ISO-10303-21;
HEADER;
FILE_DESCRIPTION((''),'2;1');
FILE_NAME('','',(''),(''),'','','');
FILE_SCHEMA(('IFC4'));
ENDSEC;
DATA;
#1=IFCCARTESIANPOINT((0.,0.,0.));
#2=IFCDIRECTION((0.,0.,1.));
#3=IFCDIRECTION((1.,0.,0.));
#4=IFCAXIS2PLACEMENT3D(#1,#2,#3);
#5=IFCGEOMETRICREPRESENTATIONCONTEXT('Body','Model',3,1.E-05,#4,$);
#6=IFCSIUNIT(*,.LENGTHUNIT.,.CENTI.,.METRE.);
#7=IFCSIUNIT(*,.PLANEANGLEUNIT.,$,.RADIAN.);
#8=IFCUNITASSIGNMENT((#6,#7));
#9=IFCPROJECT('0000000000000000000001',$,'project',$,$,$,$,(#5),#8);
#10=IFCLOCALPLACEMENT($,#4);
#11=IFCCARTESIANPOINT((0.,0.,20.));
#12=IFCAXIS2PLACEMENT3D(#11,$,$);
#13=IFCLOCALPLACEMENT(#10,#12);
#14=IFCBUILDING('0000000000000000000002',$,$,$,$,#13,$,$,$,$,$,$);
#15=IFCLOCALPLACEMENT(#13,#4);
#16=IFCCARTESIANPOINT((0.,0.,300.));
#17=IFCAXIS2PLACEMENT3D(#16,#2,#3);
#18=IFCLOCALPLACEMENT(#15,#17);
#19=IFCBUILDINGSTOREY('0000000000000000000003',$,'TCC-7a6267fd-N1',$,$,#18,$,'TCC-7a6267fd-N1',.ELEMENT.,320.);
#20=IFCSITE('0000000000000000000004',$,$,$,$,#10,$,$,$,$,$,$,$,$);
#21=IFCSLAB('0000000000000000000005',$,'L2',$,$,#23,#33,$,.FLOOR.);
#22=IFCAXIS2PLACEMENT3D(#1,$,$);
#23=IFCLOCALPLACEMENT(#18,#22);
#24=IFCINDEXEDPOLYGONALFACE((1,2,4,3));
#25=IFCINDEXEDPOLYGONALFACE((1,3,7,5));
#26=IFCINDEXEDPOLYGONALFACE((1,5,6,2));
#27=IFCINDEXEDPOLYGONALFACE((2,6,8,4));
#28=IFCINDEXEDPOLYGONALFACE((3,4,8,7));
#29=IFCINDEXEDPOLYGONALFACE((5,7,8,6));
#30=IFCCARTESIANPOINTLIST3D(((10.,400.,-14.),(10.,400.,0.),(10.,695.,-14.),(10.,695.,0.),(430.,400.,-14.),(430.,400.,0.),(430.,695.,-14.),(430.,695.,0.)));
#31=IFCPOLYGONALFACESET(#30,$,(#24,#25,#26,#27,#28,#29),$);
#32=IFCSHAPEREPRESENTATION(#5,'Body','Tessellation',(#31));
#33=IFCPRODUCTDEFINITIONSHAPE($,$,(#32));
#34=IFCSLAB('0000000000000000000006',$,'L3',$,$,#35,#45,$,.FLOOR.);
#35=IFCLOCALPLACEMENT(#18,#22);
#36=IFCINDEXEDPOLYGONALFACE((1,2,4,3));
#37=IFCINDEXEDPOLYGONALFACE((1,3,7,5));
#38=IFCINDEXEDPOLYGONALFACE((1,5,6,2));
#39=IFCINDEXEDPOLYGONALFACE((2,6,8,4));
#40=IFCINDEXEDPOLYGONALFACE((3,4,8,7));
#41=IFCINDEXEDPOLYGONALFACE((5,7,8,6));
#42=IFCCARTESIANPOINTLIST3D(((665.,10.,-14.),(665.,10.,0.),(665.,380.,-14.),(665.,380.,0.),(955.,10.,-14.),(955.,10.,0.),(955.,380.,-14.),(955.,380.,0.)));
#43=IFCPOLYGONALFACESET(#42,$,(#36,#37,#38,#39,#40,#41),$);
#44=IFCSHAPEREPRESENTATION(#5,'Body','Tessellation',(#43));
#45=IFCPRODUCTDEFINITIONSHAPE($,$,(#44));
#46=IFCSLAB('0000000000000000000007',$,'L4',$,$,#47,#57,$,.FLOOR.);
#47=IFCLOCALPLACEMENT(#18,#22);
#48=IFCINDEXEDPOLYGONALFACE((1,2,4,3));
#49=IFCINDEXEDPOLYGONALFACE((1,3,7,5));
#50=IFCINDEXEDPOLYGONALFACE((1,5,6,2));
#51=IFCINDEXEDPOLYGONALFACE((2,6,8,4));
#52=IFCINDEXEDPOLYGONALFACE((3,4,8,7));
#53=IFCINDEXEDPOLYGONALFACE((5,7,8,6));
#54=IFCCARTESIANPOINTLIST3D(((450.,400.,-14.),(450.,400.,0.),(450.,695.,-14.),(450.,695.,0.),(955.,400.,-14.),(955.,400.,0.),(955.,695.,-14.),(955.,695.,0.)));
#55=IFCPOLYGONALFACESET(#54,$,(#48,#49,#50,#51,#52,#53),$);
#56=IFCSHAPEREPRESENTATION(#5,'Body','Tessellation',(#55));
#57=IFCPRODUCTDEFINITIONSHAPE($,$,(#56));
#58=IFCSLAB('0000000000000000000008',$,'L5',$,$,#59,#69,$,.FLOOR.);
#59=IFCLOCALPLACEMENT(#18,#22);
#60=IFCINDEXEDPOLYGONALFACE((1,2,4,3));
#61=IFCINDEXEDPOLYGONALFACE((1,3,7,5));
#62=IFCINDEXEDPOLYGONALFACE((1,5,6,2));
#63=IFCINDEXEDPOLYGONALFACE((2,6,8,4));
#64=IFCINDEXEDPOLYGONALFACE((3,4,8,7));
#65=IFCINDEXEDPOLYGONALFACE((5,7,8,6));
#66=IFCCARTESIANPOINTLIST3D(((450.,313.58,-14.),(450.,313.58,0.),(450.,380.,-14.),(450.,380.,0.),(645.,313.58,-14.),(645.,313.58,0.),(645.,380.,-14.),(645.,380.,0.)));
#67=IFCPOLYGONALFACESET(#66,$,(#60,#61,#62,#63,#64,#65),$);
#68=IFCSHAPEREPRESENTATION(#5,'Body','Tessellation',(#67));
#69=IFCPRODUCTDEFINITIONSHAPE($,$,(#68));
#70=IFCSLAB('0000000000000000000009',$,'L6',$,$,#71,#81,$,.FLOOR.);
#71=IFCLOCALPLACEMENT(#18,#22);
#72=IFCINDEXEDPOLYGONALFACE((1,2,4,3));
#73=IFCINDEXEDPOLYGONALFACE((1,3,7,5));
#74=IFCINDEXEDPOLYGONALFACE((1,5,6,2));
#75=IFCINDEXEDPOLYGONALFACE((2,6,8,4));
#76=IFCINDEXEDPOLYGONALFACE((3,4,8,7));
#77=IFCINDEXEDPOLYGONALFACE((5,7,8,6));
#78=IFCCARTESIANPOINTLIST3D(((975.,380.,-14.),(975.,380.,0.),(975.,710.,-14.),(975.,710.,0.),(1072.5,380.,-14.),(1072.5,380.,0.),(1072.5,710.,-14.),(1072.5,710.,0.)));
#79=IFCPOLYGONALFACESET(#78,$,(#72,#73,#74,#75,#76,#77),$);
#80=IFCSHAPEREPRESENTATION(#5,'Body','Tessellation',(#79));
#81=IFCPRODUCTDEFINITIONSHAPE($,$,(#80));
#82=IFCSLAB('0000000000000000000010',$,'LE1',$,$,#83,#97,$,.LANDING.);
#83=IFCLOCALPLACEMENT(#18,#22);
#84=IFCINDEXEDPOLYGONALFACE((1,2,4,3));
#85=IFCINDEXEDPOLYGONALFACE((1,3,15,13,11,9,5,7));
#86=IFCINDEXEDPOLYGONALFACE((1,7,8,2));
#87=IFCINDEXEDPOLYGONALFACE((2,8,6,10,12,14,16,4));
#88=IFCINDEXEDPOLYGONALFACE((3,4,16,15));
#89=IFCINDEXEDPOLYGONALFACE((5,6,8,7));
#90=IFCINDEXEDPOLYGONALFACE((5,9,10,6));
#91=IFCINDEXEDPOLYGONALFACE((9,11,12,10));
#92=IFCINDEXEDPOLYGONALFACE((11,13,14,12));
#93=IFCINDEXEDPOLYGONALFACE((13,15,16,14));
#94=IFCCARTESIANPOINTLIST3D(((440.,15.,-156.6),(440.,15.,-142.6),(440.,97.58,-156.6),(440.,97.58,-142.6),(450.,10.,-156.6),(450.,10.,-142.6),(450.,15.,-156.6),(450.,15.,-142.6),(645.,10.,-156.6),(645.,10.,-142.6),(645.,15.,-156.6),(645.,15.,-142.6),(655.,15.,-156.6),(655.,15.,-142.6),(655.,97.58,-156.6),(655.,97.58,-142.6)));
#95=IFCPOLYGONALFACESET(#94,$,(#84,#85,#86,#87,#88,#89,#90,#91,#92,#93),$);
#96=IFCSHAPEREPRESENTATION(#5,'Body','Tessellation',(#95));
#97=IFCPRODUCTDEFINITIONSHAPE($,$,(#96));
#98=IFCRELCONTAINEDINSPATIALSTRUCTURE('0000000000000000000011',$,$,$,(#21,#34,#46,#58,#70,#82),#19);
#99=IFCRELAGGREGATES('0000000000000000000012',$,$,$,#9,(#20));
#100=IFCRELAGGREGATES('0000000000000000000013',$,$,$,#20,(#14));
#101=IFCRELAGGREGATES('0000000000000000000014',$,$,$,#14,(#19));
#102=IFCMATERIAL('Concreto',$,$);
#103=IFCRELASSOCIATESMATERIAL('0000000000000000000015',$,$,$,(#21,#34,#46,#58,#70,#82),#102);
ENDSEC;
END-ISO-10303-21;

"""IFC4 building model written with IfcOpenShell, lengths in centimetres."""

from ifc_helpers import new_model, si_unit, frame, origin_with_axes, place, context, project, spatial, polyline, outline, extrude, material, element, save


model = new_model("IFC4")

# Units and contexts
model_context = context("Model", 3, precision=1e-05, world=origin_with_axes(), identifier="Body")
ifc_project = project(units=[si_unit("LENGTHUNIT", "METRE", prefix="CENTI"), si_unit("PLANEANGLEUNIT", "RADIAN")], contexts=[model_context])

# Site, building, storey
site_placement = place(None, origin_with_axes())
site = spatial("IfcSite", under=ifc_project, at=site_placement)
building_placement = place(site_placement, frame((0.0, 0.0, 20.0)))
building = spatial("IfcBuilding", under=site, at=building_placement)
placement = place(building_placement, origin_with_axes())
storey_placement = place(placement, frame((0.0, 0.0, 300.0), z_axis=(0.0, 0.0, 1.0), x_axis=(1.0, 0.0, 0.0)))
storey = spatial("IfcBuildingStorey", under=building, at=storey_placement, Name="TCC-7a6267fd-N1", LongName="TCC-7a6267fd-N1", CompositionType="ELEMENT", Elevation=320.0)

# Shared definitions
ifc_material = material(Name="Concreto")

# Slabs
slab_1_placement = place(storey_placement, frame((220.0, 547.5, 0.0), z_axis=(0.0, 0.0, 1.0), x_axis=(1.0, 0.0, 0.0)))
element("IfcSlab", 1, at=slab_1_placement, inside=storey, material=ifc_material, Name="L2", PredefinedType="FLOOR", context=model_context, shape_type="SolidModel", body=[
    extrude(outline(polyline([(210.0, 147.5), (-210.0, 147.5), (-210.0, -147.5), (210.0, -147.5), (210.0, 147.5), (210.0, 147.5)])), frame((0.0, 0.0, -14.0), z_axis=(0.0, 0.0, 1.0), x_axis=(1.0, 0.0, 0.0)), (0.0, 0.0, 1.0), 14.0),
])
slab_2_placement = place(storey_placement, frame((810.0, 195.0, 0.0), z_axis=(0.0, 0.0, 1.0), x_axis=(1.0, 0.0, 0.0)))
element("IfcSlab", 2, at=slab_2_placement, inside=storey, material=ifc_material, Name="L3", PredefinedType="FLOOR", context=model_context, shape_type="SolidModel", body=[
    extrude(outline(polyline([(145.0, 185.0), (-145.0, 185.0), (-145.0, -185.0), (145.0, -185.0), (145.0, 185.0), (145.0, 185.0)])), frame((0.0, 0.0, -14.0), z_axis=(0.0, 0.0, 1.0), x_axis=(1.0, 0.0, 0.0)), (0.0, 0.0, 1.0), 14.0),
])
slab_3_placement = place(storey_placement, frame((702.5, 547.5, 0.0), z_axis=(0.0, 0.0, 1.0), x_axis=(1.0, 0.0, 0.0)))
element("IfcSlab", 3, at=slab_3_placement, inside=storey, material=ifc_material, Name="L4", PredefinedType="FLOOR", context=model_context, shape_type="SolidModel", body=[
    extrude(outline(polyline([(252.5, 147.5), (-252.5, 147.5), (-252.5, -147.5), (252.5, -147.5), (252.5, 147.5), (252.5, 147.5)])), frame((0.0, 0.0, -14.0), z_axis=(0.0, 0.0, 1.0), x_axis=(1.0, 0.0, 0.0)), (0.0, 0.0, 1.0), 14.0),
])
slab_4_placement = place(storey_placement, frame((547.5, 346.79, 0.0), z_axis=(0.0, 0.0, 1.0), x_axis=(1.0, 0.0, 0.0)))
element("IfcSlab", 4, at=slab_4_placement, inside=storey, material=ifc_material, Name="L5", PredefinedType="FLOOR", context=model_context, shape_type="SolidModel", body=[
    extrude(outline(polyline([(97.5, 33.21), (-97.5, 33.21), (-97.5, -33.21), (97.5, -33.21), (97.5, 33.21), (97.5, 33.21)])), frame((0.0, 0.0, -14.0), z_axis=(0.0, 0.0, 1.0), x_axis=(1.0, 0.0, 0.0)), (0.0, 0.0, 1.0), 14.0),
])
slab_5_placement = place(storey_placement, frame((1023.75, 545.0, 0.0), z_axis=(0.0, 0.0, 1.0), x_axis=(1.0, 0.0, 0.0)))
element("IfcSlab", 5, at=slab_5_placement, inside=storey, material=ifc_material, Name="L6", PredefinedType="FLOOR", context=model_context, shape_type="SolidModel", body=[
    extrude(outline(polyline([(48.75, 165.0), (-48.75, 165.0), (-48.75, -165.0), (48.75, -165.0), (48.75, 165.0), (48.75, 165.0)])), frame((0.0, 0.0, -14.0), z_axis=(0.0, 0.0, 1.0), x_axis=(1.0, 0.0, 0.0)), (0.0, 0.0, 1.0), 14.0),
])
slab_6_placement = place(storey_placement, frame((547.5, 53.79, -142.6), z_axis=(0.0, 0.0, 1.0), x_axis=(1.0, 0.0, 0.0)))
element("IfcSlab", 6, at=slab_6_placement, inside=storey, material=ifc_material, Name="LE1", PredefinedType="LANDING", context=model_context, shape_type="SolidModel", body=[
    extrude(outline(polyline([(97.5, -38.79), (107.5, -38.79), (107.5, 43.79), (-107.5, 43.79), (-107.5, -38.79), (-97.5, -38.79), (-97.5, -43.79), (97.5, -43.79), (97.5, -38.79), (97.5, -38.79)])), frame((0.0, 0.0, -14.0), z_axis=(0.0, 0.0, 1.0), x_axis=(1.0, 0.0, 0.0)), (0.0, 0.0, 1.0), 14.0),
])

save(model, "model.ifc")
